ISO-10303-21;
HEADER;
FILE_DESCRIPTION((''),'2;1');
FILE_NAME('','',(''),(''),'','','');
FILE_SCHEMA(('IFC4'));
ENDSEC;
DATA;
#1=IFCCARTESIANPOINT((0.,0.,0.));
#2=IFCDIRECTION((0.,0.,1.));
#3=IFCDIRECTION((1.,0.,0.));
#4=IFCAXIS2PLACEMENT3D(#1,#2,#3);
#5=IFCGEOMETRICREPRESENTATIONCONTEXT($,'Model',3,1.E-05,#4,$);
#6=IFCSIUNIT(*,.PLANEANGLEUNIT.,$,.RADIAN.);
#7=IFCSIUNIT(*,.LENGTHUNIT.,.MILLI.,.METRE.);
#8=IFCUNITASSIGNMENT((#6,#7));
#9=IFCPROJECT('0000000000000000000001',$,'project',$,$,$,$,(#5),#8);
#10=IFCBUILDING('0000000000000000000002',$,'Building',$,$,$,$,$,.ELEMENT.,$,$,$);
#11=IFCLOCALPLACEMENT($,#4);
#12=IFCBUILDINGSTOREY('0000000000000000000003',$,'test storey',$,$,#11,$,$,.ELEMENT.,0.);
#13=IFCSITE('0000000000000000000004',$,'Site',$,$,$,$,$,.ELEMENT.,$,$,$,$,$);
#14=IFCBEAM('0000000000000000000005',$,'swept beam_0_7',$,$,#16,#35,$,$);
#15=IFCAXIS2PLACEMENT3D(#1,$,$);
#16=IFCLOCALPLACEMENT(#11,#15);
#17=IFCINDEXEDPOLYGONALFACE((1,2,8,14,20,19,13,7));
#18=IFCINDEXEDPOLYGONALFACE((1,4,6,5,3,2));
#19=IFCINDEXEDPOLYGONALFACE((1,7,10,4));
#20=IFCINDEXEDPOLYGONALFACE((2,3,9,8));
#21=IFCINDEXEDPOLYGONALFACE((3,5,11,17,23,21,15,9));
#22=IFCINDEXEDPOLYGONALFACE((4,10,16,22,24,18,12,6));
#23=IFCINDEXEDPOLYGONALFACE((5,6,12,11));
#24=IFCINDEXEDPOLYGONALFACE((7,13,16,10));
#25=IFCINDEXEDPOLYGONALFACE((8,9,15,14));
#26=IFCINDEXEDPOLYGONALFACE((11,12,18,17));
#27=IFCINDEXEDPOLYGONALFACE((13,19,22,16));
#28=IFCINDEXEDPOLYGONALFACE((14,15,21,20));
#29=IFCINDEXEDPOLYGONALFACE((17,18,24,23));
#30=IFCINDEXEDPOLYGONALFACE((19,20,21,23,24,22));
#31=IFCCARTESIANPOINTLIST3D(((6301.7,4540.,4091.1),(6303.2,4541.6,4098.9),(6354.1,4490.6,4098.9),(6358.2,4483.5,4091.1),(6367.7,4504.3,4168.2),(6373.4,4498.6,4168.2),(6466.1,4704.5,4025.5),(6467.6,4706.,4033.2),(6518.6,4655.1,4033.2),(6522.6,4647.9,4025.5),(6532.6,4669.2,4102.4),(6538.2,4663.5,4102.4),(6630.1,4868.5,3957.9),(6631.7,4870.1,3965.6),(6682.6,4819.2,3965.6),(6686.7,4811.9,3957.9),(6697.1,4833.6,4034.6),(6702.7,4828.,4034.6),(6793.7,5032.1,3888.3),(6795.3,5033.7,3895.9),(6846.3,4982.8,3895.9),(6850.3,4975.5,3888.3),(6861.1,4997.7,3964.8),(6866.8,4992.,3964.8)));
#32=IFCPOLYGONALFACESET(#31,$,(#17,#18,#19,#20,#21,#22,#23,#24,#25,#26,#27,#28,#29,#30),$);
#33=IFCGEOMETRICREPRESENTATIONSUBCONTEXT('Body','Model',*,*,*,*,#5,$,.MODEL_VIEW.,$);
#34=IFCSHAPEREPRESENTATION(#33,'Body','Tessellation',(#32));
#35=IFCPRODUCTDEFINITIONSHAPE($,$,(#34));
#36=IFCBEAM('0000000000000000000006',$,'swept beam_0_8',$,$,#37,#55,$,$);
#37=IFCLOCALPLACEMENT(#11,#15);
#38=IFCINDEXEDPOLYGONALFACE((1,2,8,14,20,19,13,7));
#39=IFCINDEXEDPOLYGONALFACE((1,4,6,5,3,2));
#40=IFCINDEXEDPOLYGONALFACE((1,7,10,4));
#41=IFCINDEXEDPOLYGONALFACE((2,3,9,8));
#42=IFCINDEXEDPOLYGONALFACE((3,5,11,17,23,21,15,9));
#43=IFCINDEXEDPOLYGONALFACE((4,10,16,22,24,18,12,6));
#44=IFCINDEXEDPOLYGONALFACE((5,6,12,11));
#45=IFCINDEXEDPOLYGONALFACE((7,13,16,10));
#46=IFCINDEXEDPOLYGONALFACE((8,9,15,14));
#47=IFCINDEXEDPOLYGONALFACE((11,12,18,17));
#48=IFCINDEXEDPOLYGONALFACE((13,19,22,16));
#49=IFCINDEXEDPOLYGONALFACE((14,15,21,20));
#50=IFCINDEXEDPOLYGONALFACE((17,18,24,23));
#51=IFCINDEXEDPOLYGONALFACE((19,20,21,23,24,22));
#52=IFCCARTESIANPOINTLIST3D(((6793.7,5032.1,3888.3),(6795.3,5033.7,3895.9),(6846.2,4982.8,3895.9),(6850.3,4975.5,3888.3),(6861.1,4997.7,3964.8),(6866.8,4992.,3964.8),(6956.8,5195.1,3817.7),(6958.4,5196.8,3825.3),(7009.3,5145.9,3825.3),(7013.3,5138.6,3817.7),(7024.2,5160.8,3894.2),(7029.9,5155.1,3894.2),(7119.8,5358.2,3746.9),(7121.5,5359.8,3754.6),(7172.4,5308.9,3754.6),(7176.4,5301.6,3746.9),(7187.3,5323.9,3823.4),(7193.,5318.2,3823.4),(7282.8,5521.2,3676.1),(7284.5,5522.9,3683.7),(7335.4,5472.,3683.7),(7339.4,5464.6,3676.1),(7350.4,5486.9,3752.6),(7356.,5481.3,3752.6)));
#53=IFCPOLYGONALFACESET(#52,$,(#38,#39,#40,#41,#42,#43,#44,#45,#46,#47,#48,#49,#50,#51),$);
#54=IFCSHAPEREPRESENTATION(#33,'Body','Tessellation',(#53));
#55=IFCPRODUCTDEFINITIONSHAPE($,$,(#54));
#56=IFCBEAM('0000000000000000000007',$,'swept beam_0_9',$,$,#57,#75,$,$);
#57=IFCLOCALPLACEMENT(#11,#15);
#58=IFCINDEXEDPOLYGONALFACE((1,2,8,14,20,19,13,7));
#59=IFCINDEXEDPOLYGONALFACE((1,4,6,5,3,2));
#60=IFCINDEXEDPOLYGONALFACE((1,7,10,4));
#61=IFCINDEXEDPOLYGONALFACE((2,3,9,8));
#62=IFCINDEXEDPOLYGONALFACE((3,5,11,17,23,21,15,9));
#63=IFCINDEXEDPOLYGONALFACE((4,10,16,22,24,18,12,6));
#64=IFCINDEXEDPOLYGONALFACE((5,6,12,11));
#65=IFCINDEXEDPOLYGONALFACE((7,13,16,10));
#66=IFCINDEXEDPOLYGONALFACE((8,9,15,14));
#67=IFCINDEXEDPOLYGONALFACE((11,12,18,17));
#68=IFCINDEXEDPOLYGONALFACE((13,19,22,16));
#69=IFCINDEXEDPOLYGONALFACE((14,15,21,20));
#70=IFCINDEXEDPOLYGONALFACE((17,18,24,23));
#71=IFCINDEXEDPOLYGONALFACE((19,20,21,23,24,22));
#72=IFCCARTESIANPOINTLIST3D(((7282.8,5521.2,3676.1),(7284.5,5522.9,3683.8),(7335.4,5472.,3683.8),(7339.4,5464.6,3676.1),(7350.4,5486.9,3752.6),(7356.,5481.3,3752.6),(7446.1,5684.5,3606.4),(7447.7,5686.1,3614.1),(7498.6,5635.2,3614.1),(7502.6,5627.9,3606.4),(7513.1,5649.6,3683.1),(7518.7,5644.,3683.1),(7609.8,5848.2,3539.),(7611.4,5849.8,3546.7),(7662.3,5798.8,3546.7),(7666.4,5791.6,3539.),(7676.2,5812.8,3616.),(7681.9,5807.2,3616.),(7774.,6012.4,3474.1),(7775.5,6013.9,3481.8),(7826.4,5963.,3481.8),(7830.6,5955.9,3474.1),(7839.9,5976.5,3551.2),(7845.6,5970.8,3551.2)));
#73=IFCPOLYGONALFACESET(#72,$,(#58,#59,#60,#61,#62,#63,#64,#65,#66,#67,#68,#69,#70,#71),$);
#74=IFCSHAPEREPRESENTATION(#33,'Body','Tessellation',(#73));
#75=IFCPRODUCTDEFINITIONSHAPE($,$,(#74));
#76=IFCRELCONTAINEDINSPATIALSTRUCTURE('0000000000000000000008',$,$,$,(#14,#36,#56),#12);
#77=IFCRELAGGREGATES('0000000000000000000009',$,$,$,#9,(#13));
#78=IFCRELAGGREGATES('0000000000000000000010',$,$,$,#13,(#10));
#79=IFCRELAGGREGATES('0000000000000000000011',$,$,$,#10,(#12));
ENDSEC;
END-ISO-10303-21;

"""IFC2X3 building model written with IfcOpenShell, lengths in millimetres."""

from ifc_helpers import new_model, entity, si_unit, origin_with_axes, place, context, subcontext, project, spatial, element, save


model = new_model("IFC2X3")

# Units and contexts
model_context = context("Model", 3, precision=1e-05, world=origin_with_axes())
body_context = subcontext(model_context, "Body", "Model", "MODEL_VIEW")
ifc_project = project(units=[si_unit("PLANEANGLEUNIT", "RADIAN"), si_unit("LENGTHUNIT", "METRE", prefix="MILLI")], contexts=[model_context])

# Site, building, storey
site = spatial("IfcSite", under=ifc_project, Name="Site", CompositionType="ELEMENT")
building = spatial("IfcBuilding", under=site, Name="Building", CompositionType="ELEMENT")
storey_placement = place(None, origin_with_axes())
storey = spatial("IfcBuildingStorey", under=building, at=storey_placement, Name="test storey", CompositionType="ELEMENT", Elevation=0.0)

# Beams
beam_1_placement = place(storey_placement, origin_with_axes())
element("IfcBeam", 1, at=beam_1_placement, inside=storey, Name="swept beam_0_7", context=body_context, shape_type="SweptSolid", body=[
    entity("IfcRevolvedAreaSolid", entity("IfcArbitraryClosedProfileDef", "AREA", None, entity("IfcPolyline", [entity("IfcCartesianPoint", [80.0, -40.0]), entity("IfcCartesianPoint", [80.0, -32.0]), entity("IfcCartesianPoint", [8.0, -32.0]), entity("IfcCartesianPoint", [8.0, 40.0]), entity("IfcCartesianPoint", [0.0, 40.0]), entity("IfcCartesianPoint", [0.0, -40.0]), entity("IfcCartesianPoint", [80.0, -40.0])])), entity("IfcAxis2Placement3D", entity("IfcCartesianPoint", [6329.9, 4511.8, 4091.1]), entity("IfcDirection", [-0.6813, -0.6813, 0.2674]), entity("IfcDirection", [0.1891, 0.1891, 0.9636])), entity("IfcAxis1Placement", entity("IfcCartesianPoint", [-27935.6, 0.0, 0.0]), entity("IfcDirection", [0.0, 1.0, 0.0])), 0.025946),
])
beam_2_placement = place(storey_placement, origin_with_axes())
element("IfcBeam", 2, at=beam_2_placement, inside=storey, Name="swept beam_0_8", context=body_context, shape_type="SweptSolid", body=[
    entity("IfcRevolvedAreaSolid", entity("IfcArbitraryClosedProfileDef", "AREA", None, entity("IfcPolyline", [entity("IfcCartesianPoint", [80.0, -40.0]), entity("IfcCartesianPoint", [80.0, -32.0]), entity("IfcCartesianPoint", [8.0, -32.0]), entity("IfcCartesianPoint", [8.0, 40.0]), entity("IfcCartesianPoint", [0.0, 40.0]), entity("IfcCartesianPoint", [0.0, -40.0]), entity("IfcCartesianPoint", [80.0, -40.0])])), entity("IfcAxis2Placement3D", entity("IfcCartesianPoint", [6822.0, 5003.8, 3888.3]), entity("IfcDirection", [-0.6762, -0.6762, 0.2924]), entity("IfcDirection", [0.2067, 0.2067, 0.9563])), entity("IfcAxis1Placement", entity("IfcCartesianPoint", [-419880.8, 0.0, 0.0]), entity("IfcDirection", [0.0, 1.0, 0.0])), 0.001723),
])
beam_3_placement = place(storey_placement, origin_with_axes())
element("IfcBeam", 3, at=beam_3_placement, inside=storey, Name="swept beam_0_9", context=body_context, shape_type="SweptSolid", body=[
    entity("IfcRevolvedAreaSolid", entity("IfcArbitraryClosedProfileDef", "AREA", None, entity("IfcPolyline", [entity("IfcCartesianPoint", [-80.0, 40.0]), entity("IfcCartesianPoint", [-80.0, 32.0]), entity("IfcCartesianPoint", [-8.0, 32.0]), entity("IfcCartesianPoint", [-8.0, -40.0]), entity("IfcCartesianPoint", [0.0, -40.0]), entity("IfcCartesianPoint", [0.0, 40.0]), entity("IfcCartesianPoint", [-80.0, 40.0])])), entity("IfcAxis2Placement3D", entity("IfcCartesianPoint", [7311.1, 5492.9, 3676.1]), entity("IfcDirection", [-0.6759, -0.6759, 0.294]), entity("IfcDirection", [-0.2079, -0.2079, -0.9558])), entity("IfcAxis1Placement", entity("IfcCartesianPoint", [-23598.2, 0.0, 0.0]), entity("IfcDirection", [0.0, 1.0, 0.0])), 0.030659),
])

save(model, "model.ifc")
